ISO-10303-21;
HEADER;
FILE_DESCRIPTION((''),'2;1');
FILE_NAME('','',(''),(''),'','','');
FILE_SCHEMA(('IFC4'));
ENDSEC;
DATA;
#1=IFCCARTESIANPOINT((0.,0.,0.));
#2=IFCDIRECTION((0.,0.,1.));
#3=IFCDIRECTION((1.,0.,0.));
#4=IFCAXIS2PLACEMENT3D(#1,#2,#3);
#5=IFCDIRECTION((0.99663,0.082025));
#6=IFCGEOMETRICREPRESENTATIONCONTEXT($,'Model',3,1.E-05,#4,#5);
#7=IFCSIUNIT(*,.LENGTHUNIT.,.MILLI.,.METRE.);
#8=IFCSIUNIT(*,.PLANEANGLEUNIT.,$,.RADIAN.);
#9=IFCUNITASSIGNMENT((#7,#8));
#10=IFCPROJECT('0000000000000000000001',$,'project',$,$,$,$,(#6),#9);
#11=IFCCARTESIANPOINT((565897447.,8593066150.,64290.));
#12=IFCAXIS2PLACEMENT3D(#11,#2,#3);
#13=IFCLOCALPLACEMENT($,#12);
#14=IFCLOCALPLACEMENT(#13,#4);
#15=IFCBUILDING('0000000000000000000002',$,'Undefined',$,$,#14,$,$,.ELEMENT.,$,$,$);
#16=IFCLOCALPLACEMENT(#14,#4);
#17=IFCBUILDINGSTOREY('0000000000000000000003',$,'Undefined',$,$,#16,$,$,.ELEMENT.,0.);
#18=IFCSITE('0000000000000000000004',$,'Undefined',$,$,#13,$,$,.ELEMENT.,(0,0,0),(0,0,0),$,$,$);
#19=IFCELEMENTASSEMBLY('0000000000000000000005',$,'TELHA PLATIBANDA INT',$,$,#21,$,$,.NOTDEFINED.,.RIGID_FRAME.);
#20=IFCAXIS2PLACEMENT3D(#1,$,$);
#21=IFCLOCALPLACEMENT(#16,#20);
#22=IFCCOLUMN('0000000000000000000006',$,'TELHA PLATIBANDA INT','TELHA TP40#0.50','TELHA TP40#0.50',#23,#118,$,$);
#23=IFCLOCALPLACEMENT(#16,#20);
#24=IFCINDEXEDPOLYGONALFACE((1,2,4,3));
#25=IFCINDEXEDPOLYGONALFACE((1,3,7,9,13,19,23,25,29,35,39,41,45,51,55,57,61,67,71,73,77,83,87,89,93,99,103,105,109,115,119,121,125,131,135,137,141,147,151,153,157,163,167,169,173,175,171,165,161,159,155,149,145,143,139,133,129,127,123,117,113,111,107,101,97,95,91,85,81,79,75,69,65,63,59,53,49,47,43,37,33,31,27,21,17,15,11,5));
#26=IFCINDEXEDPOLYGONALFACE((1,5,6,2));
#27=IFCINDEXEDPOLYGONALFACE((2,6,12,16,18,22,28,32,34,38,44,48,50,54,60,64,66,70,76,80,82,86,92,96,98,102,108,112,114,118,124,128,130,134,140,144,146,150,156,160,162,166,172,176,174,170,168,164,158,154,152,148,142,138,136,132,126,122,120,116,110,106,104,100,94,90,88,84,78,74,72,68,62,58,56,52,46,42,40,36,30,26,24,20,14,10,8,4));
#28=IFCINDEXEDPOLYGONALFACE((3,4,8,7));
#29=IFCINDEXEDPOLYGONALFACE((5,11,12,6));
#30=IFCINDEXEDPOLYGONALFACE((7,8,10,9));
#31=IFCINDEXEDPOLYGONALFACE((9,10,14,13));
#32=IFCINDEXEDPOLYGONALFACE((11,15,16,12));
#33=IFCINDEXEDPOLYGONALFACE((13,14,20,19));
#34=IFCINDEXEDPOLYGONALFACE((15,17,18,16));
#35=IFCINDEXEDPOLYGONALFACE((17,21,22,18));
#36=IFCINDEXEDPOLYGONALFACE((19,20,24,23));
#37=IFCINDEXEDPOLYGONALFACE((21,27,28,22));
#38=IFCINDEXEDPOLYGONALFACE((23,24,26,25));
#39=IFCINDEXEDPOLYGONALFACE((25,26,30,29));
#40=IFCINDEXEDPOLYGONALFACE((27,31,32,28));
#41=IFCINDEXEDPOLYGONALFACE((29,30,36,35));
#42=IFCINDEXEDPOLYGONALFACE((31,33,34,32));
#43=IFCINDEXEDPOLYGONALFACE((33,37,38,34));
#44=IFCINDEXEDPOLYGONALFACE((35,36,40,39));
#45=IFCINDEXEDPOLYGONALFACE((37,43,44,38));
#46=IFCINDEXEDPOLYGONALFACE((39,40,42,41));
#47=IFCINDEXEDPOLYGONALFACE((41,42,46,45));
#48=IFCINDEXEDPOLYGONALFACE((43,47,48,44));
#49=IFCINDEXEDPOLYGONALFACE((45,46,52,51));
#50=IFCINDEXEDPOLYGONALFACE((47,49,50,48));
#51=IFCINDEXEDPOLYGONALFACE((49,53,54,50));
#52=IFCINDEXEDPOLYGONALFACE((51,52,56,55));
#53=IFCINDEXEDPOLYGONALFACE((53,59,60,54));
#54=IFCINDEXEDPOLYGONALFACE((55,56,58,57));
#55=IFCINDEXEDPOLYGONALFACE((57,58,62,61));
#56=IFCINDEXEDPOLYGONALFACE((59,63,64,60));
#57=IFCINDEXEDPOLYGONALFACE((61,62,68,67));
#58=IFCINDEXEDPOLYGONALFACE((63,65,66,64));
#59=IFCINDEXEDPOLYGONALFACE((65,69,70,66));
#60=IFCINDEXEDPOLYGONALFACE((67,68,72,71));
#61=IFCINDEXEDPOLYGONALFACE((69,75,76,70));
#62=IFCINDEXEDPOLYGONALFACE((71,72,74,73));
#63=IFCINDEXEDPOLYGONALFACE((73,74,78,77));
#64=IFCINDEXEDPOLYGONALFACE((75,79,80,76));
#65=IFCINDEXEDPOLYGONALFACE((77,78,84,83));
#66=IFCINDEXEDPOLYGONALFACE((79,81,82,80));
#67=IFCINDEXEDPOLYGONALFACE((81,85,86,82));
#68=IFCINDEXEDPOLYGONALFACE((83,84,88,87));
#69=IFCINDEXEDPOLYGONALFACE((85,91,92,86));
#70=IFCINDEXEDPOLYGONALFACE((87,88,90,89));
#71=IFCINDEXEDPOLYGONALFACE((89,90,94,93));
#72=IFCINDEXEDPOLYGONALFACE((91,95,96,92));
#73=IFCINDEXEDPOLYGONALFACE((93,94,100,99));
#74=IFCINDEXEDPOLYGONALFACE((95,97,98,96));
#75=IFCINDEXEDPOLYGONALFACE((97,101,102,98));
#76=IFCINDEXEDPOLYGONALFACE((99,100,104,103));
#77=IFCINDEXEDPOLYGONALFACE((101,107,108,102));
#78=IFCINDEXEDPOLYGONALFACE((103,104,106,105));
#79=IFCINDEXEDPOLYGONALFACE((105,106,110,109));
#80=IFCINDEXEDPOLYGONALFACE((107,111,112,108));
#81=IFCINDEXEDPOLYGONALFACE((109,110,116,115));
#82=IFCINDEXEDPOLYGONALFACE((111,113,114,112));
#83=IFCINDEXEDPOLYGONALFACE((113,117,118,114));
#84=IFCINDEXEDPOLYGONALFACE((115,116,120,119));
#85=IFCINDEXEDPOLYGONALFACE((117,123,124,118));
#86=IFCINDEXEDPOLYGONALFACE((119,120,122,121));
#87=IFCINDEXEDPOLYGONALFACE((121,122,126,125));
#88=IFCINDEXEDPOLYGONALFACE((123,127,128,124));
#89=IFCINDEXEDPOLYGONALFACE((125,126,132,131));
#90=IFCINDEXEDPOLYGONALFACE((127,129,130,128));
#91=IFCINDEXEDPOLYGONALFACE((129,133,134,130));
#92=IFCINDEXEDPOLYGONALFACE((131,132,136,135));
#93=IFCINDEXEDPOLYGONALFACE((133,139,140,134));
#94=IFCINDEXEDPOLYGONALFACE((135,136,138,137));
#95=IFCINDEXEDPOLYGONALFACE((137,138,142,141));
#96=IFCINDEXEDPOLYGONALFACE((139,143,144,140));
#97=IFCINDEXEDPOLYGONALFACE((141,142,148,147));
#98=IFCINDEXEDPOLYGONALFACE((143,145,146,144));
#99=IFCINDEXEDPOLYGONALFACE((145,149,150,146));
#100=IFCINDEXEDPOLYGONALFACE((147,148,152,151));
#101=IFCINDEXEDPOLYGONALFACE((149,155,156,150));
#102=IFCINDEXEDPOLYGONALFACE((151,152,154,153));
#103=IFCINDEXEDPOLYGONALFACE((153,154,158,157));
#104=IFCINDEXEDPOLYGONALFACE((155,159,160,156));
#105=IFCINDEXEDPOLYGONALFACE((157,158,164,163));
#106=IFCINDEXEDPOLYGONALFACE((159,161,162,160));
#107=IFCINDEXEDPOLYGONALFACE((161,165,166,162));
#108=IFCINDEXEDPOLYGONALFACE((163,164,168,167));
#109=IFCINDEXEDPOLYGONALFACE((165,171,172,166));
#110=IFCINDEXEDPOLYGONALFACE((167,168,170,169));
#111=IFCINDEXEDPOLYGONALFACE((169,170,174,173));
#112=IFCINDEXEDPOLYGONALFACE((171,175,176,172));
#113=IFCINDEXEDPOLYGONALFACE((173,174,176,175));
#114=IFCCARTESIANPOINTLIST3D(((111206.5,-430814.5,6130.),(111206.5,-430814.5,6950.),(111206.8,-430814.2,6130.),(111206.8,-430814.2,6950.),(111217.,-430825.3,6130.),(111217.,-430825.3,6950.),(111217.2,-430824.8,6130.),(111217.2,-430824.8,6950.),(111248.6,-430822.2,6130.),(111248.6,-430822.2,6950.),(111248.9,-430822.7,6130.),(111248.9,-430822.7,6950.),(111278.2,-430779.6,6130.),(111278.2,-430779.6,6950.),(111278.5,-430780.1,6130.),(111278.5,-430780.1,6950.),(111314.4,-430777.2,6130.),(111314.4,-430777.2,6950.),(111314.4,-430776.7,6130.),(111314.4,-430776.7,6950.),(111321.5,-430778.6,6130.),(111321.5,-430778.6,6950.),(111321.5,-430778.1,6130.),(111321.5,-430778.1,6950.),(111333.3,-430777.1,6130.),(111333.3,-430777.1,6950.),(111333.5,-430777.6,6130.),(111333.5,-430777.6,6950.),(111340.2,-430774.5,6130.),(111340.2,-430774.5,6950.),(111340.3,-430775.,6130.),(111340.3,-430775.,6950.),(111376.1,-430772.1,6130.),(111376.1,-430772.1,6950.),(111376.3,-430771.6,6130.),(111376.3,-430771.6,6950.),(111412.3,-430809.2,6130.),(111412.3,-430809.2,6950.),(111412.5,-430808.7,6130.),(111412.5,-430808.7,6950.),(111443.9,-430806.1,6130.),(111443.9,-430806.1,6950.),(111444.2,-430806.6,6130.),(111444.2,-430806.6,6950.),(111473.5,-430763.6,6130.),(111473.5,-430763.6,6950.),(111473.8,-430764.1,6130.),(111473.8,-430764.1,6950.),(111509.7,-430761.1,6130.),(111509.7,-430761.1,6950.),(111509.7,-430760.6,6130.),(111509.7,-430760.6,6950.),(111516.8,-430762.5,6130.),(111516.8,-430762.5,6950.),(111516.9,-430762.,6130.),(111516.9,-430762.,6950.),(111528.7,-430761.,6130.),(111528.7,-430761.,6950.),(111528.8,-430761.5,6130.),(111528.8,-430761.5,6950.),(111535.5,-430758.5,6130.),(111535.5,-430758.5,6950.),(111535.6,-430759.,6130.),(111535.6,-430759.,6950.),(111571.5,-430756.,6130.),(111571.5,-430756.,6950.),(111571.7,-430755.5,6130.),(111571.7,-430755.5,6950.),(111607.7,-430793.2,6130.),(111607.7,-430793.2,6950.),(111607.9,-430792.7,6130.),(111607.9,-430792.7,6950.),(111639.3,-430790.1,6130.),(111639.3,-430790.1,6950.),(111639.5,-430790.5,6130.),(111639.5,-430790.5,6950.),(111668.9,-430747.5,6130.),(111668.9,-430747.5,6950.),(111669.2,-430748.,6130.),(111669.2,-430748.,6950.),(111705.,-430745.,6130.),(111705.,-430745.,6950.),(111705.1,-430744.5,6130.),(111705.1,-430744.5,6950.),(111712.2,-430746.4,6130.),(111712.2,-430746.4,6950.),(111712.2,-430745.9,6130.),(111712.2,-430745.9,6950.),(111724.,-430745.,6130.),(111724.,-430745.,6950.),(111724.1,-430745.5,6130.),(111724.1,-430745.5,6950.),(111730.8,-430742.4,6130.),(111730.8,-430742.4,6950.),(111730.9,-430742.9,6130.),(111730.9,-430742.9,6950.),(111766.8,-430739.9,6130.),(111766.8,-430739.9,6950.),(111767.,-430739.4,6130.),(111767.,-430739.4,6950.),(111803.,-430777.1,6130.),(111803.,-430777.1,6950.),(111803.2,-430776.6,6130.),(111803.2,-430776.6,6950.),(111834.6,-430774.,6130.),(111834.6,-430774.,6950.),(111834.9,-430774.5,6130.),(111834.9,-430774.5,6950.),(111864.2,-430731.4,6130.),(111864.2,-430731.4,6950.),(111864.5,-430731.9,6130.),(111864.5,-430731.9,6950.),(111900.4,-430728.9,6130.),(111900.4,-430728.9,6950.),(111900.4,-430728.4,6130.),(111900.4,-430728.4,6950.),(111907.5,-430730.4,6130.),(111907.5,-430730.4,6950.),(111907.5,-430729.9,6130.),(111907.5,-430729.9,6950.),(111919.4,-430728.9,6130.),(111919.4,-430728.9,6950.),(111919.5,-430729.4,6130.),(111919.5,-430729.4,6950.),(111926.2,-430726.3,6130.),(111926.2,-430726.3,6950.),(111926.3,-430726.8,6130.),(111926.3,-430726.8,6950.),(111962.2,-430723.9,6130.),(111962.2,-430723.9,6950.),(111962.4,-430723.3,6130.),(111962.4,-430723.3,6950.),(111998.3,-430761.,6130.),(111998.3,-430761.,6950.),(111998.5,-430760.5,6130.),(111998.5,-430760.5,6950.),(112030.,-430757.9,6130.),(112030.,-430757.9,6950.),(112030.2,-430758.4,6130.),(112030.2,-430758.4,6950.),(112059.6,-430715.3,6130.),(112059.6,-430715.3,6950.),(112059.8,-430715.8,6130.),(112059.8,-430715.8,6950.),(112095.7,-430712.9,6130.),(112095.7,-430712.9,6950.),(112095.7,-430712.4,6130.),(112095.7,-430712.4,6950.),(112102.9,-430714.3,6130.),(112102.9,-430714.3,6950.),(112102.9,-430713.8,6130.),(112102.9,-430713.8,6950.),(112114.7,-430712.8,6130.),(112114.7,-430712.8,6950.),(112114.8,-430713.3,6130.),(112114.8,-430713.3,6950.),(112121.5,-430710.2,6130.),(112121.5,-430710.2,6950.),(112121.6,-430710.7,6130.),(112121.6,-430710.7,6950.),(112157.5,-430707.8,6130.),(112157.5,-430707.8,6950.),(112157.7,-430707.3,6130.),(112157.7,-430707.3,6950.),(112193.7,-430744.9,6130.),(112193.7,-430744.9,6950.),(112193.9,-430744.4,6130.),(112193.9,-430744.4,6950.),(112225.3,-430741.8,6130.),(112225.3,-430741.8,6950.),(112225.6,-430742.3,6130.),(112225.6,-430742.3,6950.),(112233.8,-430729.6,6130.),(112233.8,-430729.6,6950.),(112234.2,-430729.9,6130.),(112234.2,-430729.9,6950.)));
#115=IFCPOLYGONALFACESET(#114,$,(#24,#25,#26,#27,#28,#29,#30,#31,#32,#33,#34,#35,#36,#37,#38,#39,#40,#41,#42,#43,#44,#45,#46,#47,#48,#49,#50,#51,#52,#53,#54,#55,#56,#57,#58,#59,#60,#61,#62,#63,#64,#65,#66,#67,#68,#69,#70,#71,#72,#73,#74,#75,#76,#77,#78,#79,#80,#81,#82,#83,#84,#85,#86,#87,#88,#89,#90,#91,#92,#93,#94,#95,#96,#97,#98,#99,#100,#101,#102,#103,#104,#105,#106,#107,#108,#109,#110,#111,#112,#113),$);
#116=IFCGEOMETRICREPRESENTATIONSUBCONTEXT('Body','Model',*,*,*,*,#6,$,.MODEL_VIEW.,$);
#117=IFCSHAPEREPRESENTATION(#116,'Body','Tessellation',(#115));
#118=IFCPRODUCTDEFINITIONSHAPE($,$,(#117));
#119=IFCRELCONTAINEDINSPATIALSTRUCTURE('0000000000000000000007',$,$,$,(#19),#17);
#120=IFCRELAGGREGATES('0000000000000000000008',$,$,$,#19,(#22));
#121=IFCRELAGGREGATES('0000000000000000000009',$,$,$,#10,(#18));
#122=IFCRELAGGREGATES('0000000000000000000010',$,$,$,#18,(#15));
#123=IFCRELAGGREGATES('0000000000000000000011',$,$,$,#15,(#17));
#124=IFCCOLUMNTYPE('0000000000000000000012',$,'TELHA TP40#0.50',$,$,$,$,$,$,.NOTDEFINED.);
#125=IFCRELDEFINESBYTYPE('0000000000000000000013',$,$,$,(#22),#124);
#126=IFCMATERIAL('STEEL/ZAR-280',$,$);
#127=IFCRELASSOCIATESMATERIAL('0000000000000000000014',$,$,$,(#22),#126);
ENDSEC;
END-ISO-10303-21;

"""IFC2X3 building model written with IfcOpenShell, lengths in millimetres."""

from ifc_helpers import new_model, si_unit, direction, frame, origin_with_axes, place, context, subcontext, project, spatial, polyline, outline, extrude, material, type_object, element, aggregate, save


model = new_model("IFC2X3")

# Units and contexts
model_context = context("Model", 3, precision=1e-05, world=origin_with_axes(), true_north=direction((0.99663, 0.082025)))
body_context = subcontext(model_context, "Body", "Model", "MODEL_VIEW")
ifc_project = project(units=[si_unit("LENGTHUNIT", "METRE", prefix="MILLI"), si_unit("PLANEANGLEUNIT", "RADIAN")], contexts=[model_context])

# Site, building, storey
site_placement = place(None, frame((565897447.0, 8593066150.0, 64290.0), z_axis=(0.0, 0.0, 1.0), x_axis=(1.0, 0.0, 0.0)))
site = spatial("IfcSite", under=ifc_project, at=site_placement, Name="Undefined", CompositionType="ELEMENT", RefLatitude=(0, 0, 0), RefLongitude=(0, 0, 0))
building_placement = place(site_placement, origin_with_axes())
building = spatial("IfcBuilding", under=site, at=building_placement, Name="Undefined", CompositionType="ELEMENT")
storey_placement = place(building_placement, origin_with_axes())
storey = spatial("IfcBuildingStorey", under=building, at=storey_placement, Name="Undefined", CompositionType="ELEMENT", Elevation=0.0)

# Element assembly, column
ifc_material_1 = material(Name="STEEL/ZAR-280")
column_type = type_object("IfcColumnType", Name="TELHA TP40#0.50", PredefinedType="NOTDEFINED")
assembly_1_placement = place(storey_placement, origin_with_axes())
assembly_1 = element("IfcElementAssembly", 1, at=assembly_1_placement, inside=storey, Name="TELHA PLATIBANDA INT", AssemblyPlace="NOTDEFINED", PredefinedType="RIGID_FRAME")
column_1_placement = place(assembly_1_placement, frame((111719.8, -430763.6, 6130.0), z_axis=(0.0, 0.0, 1.0), x_axis=(0.082025, -0.99663, 0.0)))
column_1 = element("IfcColumn", 2, at=column_1_placement, type_object=column_type, material=ifc_material_1, Name="TELHA PLATIBANDA INT", Description="TELHA TP40#0.50", ObjectType="TELHA TP40#0.50", context=body_context, shape_type="SweptSolid", body=[
    extrude(outline(polyline([(440.8, -19.8), (473.8, 20.2), (505.8, 20.2), (515.4, 8.6), (515.0, 8.3), (505.6, 19.8), (474.0, 19.8), (441.0, -20.2), (404.7, -20.2), (397.7, -18.2), (385.9, -18.2), (378.9, -20.2), (342.6, -20.2), (309.6, 19.8), (278.0, 19.8), (245.0, -20.2), (208.7, -20.2), (201.7, -18.2), (189.9, -18.2), (182.9, -20.2), (146.6, -20.2), (113.6, 19.8), (82.0, 19.8), (49.0, -20.2), (12.7, -20.2), (5.7, -18.2), (-6.1, -18.2), (-13.1, -20.2), (-49.4, -20.2), (-82.4, 19.8), (-114.0, 19.8), (-147.0, -20.2), (-183.3, -20.2), (-190.3, -18.2), (-202.1, -18.2), (-209.1, -20.2), (-245.4, -20.2), (-278.4, 19.8), (-310.0, 19.8), (-343.0, -20.2), (-379.3, -20.2), (-386.3, -18.2), (-398.1, -18.2), (-405.1, -20.2), (-441.4, -20.2), (-474.4, 19.8), (-506.0, 19.8), (-515.4, 8.3), (-515.8, 8.6), (-506.2, 20.2), (-474.2, 20.2), (-441.2, -19.8), (-405.2, -19.8), (-398.2, -17.8), (-386.2, -17.8), (-379.2, -19.8), (-343.2, -19.8), (-310.2, 20.2), (-278.2, 20.2), (-245.2, -19.8), (-209.2, -19.8), (-202.2, -17.8), (-190.2, -17.8), (-183.2, -19.8), (-147.2, -19.8), (-114.2, 20.2), (-82.2, 20.2), (-49.2, -19.8), (-13.2, -19.8), (-6.2, -17.8), (5.8, -17.8), (12.8, -19.8), (48.8, -19.8), (81.8, 20.2), (113.8, 20.2), (146.8, -19.8), (182.8, -19.8), (189.8, -17.8), (201.8, -17.8), (208.8, -19.8), (244.8, -19.8), (277.8, 20.2), (309.8, 20.2), (342.8, -19.8), (378.8, -19.8), (385.8, -17.8), (397.8, -17.8), (404.8, -19.8), (440.8, -19.8)])), frame((0.0, 0.0, 820.0), z_axis=(0.0, 0.0, -1.0), x_axis=(0.0, 1.0, 0.0)), (0.0, 0.0, 1.0), 820.0),
])
aggregate(assembly_1, [column_1])

save(model, "model.ifc")
